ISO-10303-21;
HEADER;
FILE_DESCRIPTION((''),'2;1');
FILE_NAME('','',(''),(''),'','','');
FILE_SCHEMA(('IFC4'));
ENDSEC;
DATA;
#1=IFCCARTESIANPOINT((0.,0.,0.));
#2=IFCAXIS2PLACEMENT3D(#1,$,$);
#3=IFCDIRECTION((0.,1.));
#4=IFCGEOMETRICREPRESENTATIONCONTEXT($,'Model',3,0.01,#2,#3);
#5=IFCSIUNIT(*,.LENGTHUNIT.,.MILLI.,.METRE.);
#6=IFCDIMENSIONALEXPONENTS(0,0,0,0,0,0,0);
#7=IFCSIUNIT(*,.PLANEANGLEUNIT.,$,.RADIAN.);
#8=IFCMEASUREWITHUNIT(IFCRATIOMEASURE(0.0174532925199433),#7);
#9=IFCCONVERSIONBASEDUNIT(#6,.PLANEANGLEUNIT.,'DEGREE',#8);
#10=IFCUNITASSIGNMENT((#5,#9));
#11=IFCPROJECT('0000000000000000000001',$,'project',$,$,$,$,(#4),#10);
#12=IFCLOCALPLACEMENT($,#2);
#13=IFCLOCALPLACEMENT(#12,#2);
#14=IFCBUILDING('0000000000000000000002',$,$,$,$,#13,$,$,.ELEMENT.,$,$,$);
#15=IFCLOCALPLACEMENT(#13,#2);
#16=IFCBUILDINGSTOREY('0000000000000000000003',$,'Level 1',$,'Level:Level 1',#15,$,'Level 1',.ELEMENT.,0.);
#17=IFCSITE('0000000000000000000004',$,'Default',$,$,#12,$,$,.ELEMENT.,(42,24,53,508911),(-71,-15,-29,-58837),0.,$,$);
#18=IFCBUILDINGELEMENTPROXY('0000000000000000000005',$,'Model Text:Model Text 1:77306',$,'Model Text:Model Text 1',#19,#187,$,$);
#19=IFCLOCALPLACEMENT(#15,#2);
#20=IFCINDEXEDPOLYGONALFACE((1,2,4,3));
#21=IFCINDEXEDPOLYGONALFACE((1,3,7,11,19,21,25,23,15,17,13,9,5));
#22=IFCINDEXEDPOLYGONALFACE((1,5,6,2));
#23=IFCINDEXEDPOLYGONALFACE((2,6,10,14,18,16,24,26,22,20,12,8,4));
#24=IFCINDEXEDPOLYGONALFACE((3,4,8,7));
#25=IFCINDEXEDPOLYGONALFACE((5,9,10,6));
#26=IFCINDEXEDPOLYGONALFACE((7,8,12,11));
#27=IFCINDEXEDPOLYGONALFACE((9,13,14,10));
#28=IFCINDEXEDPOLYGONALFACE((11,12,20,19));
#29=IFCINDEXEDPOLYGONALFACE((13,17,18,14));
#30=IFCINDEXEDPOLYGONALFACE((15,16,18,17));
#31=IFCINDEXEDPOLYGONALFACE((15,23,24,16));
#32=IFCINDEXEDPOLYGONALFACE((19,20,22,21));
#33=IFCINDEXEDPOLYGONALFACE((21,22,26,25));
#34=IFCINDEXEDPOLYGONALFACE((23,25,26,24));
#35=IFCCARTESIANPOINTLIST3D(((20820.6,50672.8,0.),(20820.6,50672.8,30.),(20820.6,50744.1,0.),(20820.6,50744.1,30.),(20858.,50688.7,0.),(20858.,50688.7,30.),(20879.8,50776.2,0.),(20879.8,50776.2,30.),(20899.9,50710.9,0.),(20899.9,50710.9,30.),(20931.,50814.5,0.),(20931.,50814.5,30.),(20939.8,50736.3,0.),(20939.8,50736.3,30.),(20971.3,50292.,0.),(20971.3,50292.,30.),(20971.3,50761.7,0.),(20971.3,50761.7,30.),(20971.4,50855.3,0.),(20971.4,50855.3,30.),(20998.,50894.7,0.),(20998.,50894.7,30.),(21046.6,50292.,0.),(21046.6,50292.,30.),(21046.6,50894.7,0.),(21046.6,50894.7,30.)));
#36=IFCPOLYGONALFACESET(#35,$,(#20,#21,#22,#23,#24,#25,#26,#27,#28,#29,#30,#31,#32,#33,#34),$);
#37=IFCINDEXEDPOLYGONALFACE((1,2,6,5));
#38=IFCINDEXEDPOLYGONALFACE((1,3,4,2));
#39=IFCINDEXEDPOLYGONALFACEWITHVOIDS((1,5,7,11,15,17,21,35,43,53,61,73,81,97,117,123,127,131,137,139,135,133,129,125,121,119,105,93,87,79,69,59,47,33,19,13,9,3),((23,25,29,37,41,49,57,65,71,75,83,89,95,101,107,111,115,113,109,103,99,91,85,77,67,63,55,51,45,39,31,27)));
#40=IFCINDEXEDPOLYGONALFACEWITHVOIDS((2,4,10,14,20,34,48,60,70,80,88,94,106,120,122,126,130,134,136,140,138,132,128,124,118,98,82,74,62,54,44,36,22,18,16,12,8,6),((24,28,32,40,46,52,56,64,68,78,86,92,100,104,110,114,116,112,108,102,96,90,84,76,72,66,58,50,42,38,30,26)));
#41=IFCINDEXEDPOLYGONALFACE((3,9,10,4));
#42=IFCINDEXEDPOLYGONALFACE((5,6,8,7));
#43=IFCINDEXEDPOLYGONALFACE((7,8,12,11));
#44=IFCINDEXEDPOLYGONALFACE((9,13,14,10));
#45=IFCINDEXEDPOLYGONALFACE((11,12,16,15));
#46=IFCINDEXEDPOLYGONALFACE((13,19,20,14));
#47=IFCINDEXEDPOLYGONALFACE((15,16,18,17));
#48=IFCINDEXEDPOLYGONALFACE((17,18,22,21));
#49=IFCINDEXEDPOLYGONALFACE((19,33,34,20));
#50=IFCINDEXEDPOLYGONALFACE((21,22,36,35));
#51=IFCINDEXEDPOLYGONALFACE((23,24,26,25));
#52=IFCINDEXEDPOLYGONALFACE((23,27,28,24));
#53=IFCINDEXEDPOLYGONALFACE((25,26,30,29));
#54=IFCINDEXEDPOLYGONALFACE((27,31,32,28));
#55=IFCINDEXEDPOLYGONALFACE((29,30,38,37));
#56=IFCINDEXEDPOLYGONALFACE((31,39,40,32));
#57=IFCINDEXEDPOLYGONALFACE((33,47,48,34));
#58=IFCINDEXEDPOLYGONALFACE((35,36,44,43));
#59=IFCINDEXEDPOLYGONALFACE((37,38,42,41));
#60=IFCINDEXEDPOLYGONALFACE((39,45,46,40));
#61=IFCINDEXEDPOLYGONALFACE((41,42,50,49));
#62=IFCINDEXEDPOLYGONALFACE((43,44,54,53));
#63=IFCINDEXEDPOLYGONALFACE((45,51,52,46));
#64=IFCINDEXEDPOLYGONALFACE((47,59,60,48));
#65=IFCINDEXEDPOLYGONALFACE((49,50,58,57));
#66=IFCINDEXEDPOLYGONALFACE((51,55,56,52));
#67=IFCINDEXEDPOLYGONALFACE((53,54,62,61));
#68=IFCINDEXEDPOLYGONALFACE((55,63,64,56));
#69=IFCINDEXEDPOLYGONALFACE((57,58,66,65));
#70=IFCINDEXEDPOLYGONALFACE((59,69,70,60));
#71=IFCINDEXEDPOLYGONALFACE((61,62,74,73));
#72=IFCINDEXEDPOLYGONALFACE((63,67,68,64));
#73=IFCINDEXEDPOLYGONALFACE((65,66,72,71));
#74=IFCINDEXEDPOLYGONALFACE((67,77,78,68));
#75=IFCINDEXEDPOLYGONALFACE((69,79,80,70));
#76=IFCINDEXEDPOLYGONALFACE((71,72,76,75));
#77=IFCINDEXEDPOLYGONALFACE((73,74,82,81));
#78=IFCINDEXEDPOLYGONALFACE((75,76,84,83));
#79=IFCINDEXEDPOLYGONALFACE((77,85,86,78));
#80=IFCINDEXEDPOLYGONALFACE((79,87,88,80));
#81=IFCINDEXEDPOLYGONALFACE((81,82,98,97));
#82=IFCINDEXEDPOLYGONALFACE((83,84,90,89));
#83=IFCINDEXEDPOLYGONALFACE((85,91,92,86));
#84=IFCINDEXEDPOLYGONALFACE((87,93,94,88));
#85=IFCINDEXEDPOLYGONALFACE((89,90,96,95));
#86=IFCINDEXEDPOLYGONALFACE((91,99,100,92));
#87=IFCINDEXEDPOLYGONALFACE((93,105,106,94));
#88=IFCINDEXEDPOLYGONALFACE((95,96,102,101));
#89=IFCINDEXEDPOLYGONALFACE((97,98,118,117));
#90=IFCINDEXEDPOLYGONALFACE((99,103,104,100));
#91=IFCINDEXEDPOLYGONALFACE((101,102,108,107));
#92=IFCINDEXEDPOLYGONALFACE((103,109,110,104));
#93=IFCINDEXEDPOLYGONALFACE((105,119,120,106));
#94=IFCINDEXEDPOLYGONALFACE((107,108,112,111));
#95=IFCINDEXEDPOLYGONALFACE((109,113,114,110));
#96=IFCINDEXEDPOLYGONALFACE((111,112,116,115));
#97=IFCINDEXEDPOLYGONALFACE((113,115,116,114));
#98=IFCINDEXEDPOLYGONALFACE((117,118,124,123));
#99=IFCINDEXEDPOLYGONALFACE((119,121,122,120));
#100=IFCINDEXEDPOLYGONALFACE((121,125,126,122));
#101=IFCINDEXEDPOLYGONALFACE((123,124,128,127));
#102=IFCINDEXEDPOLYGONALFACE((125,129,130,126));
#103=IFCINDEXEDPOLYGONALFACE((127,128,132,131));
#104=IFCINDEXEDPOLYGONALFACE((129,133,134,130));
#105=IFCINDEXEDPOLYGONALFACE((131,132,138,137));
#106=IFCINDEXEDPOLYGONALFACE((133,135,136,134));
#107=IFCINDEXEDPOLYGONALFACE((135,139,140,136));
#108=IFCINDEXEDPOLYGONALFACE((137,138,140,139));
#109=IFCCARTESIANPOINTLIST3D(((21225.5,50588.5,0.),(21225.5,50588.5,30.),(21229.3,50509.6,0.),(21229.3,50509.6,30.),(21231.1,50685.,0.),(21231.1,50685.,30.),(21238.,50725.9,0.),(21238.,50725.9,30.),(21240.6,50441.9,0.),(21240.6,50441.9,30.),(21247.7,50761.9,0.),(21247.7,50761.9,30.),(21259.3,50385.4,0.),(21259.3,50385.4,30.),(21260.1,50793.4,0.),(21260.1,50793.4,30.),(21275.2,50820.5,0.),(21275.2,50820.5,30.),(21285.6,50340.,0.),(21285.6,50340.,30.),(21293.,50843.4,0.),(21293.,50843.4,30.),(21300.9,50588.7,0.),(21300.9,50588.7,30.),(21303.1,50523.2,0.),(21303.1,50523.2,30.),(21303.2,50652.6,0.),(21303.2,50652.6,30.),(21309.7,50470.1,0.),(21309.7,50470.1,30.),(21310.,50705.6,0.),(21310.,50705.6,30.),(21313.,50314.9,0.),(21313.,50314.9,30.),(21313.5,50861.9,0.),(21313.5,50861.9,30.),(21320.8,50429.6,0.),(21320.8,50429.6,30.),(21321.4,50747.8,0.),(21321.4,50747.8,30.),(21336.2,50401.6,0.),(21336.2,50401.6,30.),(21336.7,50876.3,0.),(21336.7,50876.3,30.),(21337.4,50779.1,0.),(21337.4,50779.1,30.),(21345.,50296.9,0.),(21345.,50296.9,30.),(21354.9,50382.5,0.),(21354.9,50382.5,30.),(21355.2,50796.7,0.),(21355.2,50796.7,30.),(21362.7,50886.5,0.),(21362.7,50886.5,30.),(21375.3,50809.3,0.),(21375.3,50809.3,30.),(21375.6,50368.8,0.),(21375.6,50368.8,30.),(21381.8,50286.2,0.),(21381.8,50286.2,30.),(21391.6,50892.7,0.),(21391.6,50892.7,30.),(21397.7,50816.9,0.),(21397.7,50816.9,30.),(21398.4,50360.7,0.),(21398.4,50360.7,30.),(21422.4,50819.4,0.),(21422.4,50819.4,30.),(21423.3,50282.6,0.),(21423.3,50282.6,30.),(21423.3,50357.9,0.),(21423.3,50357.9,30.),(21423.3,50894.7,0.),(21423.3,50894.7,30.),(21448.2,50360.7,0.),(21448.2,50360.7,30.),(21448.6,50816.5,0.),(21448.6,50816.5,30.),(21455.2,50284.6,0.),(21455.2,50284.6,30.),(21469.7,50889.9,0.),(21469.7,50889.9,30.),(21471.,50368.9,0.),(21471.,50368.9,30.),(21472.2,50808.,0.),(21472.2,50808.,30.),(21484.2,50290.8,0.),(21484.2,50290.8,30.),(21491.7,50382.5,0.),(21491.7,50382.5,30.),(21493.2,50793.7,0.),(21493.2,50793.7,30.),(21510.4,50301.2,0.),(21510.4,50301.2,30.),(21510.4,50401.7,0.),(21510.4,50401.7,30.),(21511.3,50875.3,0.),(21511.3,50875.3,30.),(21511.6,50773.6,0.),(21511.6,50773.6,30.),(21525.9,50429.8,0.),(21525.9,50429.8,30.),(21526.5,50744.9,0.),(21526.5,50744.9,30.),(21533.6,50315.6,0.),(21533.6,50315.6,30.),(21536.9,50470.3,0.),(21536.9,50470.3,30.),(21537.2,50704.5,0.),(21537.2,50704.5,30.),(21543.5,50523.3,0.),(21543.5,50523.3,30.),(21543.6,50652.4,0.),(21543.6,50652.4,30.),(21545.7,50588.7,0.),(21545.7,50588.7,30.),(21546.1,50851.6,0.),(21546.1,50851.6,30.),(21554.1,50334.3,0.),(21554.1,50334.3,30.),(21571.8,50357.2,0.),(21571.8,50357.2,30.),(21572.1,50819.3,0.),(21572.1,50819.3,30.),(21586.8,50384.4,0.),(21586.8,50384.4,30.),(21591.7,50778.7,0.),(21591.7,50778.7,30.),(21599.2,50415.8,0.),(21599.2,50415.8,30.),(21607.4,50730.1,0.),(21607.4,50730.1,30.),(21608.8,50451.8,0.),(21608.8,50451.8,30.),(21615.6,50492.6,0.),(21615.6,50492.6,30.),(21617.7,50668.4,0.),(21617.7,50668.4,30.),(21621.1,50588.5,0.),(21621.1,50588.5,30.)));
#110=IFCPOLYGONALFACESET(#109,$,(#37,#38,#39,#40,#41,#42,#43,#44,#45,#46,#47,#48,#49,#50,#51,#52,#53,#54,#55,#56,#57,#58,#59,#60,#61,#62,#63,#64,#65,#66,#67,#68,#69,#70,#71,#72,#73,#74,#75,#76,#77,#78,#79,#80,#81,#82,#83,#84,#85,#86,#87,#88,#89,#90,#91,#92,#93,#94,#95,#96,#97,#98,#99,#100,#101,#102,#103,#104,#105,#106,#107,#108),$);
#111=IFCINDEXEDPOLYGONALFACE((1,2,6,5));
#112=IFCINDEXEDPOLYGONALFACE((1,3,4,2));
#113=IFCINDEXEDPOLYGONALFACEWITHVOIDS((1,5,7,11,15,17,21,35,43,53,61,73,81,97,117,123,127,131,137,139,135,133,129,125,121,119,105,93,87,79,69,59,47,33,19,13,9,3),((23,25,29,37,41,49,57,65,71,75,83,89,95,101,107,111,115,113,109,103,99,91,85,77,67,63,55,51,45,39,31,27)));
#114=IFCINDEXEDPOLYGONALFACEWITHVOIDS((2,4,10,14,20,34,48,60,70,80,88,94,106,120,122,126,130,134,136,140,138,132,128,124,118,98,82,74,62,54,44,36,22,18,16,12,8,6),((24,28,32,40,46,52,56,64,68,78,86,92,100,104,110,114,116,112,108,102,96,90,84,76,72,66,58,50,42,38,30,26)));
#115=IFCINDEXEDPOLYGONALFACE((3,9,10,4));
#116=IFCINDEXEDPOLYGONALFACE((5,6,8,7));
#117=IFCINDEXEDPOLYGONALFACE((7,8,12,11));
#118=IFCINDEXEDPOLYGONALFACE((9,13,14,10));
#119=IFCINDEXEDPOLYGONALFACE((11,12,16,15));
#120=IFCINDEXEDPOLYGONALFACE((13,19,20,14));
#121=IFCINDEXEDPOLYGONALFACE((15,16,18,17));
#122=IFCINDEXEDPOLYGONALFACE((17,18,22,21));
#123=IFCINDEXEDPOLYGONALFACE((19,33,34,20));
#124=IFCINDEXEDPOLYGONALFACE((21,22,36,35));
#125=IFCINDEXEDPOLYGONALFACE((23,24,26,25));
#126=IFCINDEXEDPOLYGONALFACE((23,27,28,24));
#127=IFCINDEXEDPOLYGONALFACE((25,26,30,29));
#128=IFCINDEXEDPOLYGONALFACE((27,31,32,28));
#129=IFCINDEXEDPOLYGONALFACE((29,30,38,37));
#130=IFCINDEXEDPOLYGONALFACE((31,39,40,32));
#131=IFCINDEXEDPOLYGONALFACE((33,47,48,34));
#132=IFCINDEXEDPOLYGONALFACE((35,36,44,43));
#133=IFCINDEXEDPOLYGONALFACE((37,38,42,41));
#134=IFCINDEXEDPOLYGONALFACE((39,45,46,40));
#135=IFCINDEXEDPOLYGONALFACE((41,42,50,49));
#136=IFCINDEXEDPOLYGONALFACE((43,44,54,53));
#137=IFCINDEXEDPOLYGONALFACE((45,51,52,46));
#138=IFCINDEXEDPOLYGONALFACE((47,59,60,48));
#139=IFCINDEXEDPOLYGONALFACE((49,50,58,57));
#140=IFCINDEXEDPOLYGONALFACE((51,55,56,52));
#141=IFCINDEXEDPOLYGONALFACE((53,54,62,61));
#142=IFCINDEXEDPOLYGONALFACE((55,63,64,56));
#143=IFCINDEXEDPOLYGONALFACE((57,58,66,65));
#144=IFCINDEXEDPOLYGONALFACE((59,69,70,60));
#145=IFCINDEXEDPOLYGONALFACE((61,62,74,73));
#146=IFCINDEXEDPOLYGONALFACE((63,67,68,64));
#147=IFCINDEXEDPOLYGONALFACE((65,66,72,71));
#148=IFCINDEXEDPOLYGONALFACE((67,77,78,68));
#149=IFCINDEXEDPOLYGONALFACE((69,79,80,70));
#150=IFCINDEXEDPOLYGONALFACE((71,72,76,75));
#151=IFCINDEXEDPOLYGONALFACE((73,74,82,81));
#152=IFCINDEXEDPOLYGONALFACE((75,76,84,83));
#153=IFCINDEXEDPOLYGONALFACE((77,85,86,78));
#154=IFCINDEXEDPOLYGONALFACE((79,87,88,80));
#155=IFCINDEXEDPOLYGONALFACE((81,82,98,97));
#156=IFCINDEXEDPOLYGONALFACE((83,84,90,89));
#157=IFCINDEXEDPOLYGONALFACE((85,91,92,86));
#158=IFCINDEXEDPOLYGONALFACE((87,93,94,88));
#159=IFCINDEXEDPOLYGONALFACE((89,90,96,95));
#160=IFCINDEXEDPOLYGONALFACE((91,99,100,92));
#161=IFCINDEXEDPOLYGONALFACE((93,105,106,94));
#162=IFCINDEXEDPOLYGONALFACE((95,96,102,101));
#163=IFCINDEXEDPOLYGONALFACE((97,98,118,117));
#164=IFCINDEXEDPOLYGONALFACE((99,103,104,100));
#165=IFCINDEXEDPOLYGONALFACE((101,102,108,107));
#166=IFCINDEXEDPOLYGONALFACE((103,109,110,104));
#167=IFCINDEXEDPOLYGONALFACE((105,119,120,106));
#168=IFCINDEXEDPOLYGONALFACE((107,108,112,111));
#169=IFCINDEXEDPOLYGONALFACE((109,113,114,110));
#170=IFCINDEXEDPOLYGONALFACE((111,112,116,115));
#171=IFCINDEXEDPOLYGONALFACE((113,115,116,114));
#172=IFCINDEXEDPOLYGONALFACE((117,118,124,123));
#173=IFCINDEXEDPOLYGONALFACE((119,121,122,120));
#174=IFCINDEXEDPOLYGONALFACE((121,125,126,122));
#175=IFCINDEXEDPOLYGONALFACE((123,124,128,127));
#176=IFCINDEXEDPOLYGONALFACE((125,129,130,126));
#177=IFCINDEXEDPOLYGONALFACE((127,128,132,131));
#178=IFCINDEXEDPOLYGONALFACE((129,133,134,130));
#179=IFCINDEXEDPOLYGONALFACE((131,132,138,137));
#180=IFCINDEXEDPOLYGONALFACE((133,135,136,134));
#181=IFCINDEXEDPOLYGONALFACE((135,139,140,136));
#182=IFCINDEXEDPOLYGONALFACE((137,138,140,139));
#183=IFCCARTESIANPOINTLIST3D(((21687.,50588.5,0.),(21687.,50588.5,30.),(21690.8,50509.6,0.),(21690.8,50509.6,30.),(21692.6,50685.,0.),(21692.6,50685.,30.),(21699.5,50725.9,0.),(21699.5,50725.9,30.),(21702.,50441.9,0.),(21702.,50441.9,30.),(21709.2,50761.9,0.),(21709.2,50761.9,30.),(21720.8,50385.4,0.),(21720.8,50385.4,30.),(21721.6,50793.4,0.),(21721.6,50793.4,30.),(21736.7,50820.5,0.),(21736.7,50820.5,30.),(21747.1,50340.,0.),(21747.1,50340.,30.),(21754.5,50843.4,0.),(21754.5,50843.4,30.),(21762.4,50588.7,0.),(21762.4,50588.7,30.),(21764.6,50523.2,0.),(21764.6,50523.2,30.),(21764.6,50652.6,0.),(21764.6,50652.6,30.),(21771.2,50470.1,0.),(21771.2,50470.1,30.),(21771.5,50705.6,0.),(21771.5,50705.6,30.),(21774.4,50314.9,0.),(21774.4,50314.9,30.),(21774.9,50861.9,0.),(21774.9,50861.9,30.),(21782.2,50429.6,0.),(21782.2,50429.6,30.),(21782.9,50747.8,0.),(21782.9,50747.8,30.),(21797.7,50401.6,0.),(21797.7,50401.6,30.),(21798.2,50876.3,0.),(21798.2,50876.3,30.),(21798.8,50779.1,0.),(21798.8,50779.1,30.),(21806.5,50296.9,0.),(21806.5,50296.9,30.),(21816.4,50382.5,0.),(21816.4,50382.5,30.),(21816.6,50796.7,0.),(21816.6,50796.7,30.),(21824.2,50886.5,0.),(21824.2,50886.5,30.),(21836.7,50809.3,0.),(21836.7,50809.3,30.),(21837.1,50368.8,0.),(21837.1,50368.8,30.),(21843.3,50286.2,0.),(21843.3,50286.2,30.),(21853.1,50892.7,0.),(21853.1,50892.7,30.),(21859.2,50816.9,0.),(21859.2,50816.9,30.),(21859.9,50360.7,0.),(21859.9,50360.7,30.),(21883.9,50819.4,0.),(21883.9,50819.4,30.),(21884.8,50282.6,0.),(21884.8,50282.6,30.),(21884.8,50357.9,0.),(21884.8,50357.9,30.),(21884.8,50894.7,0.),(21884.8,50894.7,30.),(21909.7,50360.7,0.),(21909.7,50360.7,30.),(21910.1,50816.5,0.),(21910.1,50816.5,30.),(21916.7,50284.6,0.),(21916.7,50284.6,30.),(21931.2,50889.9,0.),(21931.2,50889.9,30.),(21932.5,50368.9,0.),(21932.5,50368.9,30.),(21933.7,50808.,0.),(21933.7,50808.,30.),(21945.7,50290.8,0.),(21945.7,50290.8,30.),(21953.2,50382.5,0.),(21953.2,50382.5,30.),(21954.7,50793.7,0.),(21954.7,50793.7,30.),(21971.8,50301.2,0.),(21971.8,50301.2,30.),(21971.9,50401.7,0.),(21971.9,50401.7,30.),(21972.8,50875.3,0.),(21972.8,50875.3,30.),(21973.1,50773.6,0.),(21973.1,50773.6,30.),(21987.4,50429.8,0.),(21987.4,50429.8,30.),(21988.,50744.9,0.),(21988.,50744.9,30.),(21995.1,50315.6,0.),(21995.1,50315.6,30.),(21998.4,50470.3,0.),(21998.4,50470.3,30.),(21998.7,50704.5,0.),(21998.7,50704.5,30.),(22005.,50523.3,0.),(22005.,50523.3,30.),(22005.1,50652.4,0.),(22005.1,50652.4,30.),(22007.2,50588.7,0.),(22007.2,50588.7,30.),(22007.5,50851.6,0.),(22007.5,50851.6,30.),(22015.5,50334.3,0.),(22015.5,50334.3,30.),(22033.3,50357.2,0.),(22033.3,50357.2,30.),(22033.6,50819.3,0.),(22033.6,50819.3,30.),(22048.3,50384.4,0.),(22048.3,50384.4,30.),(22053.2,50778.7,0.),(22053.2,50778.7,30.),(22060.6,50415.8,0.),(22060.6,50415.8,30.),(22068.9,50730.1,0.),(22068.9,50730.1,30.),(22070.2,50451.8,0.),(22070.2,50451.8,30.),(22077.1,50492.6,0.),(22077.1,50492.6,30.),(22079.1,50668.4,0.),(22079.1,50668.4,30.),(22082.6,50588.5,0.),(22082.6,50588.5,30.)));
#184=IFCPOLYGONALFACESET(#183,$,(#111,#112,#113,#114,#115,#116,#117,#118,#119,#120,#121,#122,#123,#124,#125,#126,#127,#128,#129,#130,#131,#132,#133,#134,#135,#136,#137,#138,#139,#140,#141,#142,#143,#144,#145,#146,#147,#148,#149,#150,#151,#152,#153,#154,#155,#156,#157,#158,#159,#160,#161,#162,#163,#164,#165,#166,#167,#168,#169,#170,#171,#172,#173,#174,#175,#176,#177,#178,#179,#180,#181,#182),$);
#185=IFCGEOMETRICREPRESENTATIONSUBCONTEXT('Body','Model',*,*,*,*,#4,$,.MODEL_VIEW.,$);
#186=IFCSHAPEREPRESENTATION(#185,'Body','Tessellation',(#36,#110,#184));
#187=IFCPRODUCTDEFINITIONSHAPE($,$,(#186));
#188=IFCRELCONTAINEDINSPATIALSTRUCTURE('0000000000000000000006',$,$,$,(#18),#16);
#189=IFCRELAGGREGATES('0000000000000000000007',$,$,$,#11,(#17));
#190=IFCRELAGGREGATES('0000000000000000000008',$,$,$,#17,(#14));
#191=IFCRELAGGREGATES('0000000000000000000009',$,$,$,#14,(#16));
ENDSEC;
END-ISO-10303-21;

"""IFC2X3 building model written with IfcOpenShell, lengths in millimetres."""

from ifc_helpers import new_model, entity, si_unit, converted_unit, direction, frame, origin, place, context, subcontext, project, spatial, polyline, outline, extrude, element, save


model = new_model("IFC2X3")

# Units and contexts
model_context = context("Model", 3, precision=0.01, world=origin(), true_north=direction((0.0, 1.0)))
body_context = subcontext(model_context, "Body", "Model", "MODEL_VIEW")
ifc_project = project(units=[si_unit("LENGTHUNIT", "METRE", prefix="MILLI"), converted_unit("PLANEANGLEUNIT", "DEGREE", entity("IfcRatioMeasure", 0.0174532925199433), si_unit("PLANEANGLEUNIT", "RADIAN"), dimensions=[0, 0, 0, 0, 0, 0, 0])], contexts=[model_context])

# Site, building, storey
site_placement = place(None, origin())
site = spatial("IfcSite", under=ifc_project, at=site_placement, Name="Default", CompositionType="ELEMENT", RefLatitude=(42, 24, 53, 508911), RefLongitude=(-71, -15, -29, -58837), RefElevation=0.0)
building_placement = place(site_placement, origin())
building = spatial("IfcBuilding", under=site, at=building_placement, CompositionType="ELEMENT")
storey_placement = place(building_placement, origin())
storey = spatial("IfcBuildingStorey", under=building, at=storey_placement, Name="Level 1", ObjectType="Level:Level 1", LongName="Level 1", CompositionType="ELEMENT", Elevation=0.0)

# Building element proxy
proxy_1_placement = place(storey_placement, origin())
element("IfcBuildingElementProxy", 1, at=proxy_1_placement, inside=storey, Name="Model Text:Model Text 1:77306", ObjectType="Model Text:Model Text 1", context=body_context, shape_type="SweptSolid", body=[
    extrude(outline(polyline([(-410.6, -111.6), (192.1, -111.6), (192.1, -63.1), (152.7, -36.4), (111.9, 4.0), (73.6, 55.2), (41.4, 114.4), (-29.8, 114.4), (-13.9, 77.0), (8.3, 35.1), (33.7, -4.8), (59.1, -36.3), (-410.6, -36.3), (-410.6, -111.6)])), frame((20935.0, 50702.6, 0.0), z_axis=(0.0, 0.0, 1.0), x_axis=(0.0, 1.0, 0.0)), (0.0, 0.0, 1.0), 30.0),
    extrude(outline(polyline([(-10.6, -198.7), (68.3, -198.7), (136.5, -190.7), (193.9, -174.7), (240.5, -150.6), (266.9, -124.4), (286.3, -93.2), (298.8, -57.0), (304.3, -15.7), (303.8, 16.2), (299.0, 45.5), (289.9, 72.1), (276.6, 96.0), (258.9, 117.3), (236.9, 136.2), (210.4, 152.5), (179.6, 166.3), (144.1, 177.6), (103.7, 186.3), (8.2, 196.4), (-71.8, 196.7), (-134.0, 189.4), (-183.3, 176.1), (-224.7, 158.4), (-258.2, 133.9), (-283.5, 100.3), (-300.1, 59.5), (-307.1, 13.4), (-306.6, -18.4), (-301.8, -47.5), (-292.8, -74.0), (-279.6, -97.9), (-262.0, -119.2), (-240.0, -138.1), (-213.6, -154.5), (-182.8, -168.4), (-147.3, -179.8), (-106.7, -188.6), (-10.6, -198.7)]), holes=[polyline([(-7.2, -123.5), (-71.0, -118.2), (-123.6, -108.8), (-165.2, -95.4), (-195.7, -78.0), (-212.4, -59.4), (-224.1, -38.7), (-230.6, -15.9), (-231.9, 8.9), (-227.8, 35.0), (-218.1, 58.1), (-202.8, 78.4), (-182.0, 95.8), (-152.6, 109.4), (-111.7, 118.1), (-59.4, 122.0), (4.4, 121.1), (69.6, 115.8), (122.2, 106.7), (162.2, 93.7), (189.5, 77.0), (207.7, 57.4), (220.4, 36.0), (227.5, 12.8), (229.1, -12.1), (225.2, -36.8), (215.9, -59.2), (201.3, -79.3), (181.4, -97.1), (152.6, -111.2), (111.6, -120.3), (58.3, -124.4), (-7.2, -123.5)])]), frame((21424.6, 50587.3, 0.0), z_axis=(0.0, 0.0, 1.0), x_axis=(0.047515, -0.998871, 0.0)), (0.0, 0.0, 1.0), 30.0),
    extrude(outline(polyline([(-10.6, -198.7), (68.3, -198.7), (136.5, -190.7), (193.9, -174.7), (240.5, -150.6), (266.9, -124.4), (286.3, -93.2), (298.8, -57.0), (304.3, -15.7), (303.8, 16.2), (299.0, 45.5), (289.9, 72.1), (276.6, 96.0), (258.9, 117.3), (236.9, 136.2), (210.4, 152.5), (179.6, 166.3), (144.1, 177.6), (103.7, 186.3), (8.2, 196.4), (-71.8, 196.7), (-134.0, 189.4), (-183.3, 176.1), (-224.7, 158.4), (-258.2, 133.9), (-283.5, 100.3), (-300.1, 59.5), (-307.1, 13.4), (-306.6, -18.4), (-301.8, -47.5), (-292.8, -74.0), (-279.6, -97.9), (-262.0, -119.2), (-240.0, -138.1), (-213.6, -154.5), (-182.8, -168.4), (-147.3, -179.8), (-106.7, -188.6), (-10.6, -198.7)]), holes=[polyline([(-7.2, -123.5), (-71.0, -118.2), (-123.6, -108.8), (-165.2, -95.4), (-195.7, -78.0), (-212.4, -59.4), (-224.1, -38.7), (-230.6, -15.9), (-231.9, 8.9), (-227.8, 35.0), (-218.1, 58.1), (-202.8, 78.4), (-182.0, 95.8), (-152.6, 109.4), (-111.7, 118.1), (-59.4, 122.0), (4.4, 121.1), (69.6, 115.8), (122.2, 106.7), (162.2, 93.7), (189.5, 77.0), (207.7, 57.4), (220.4, 36.0), (227.5, 12.8), (229.1, -12.1), (225.2, -36.8), (215.9, -59.2), (201.3, -79.3), (181.4, -97.1), (152.6, -111.2), (111.6, -120.3), (58.3, -124.4), (-7.2, -123.5)])]), frame((21886.0, 50587.3, 0.0), z_axis=(0.0, 0.0, 1.0), x_axis=(0.047515, -0.998871, 0.0)), (0.0, 0.0, 1.0), 30.0),
])

save(model, "model.ifc")
